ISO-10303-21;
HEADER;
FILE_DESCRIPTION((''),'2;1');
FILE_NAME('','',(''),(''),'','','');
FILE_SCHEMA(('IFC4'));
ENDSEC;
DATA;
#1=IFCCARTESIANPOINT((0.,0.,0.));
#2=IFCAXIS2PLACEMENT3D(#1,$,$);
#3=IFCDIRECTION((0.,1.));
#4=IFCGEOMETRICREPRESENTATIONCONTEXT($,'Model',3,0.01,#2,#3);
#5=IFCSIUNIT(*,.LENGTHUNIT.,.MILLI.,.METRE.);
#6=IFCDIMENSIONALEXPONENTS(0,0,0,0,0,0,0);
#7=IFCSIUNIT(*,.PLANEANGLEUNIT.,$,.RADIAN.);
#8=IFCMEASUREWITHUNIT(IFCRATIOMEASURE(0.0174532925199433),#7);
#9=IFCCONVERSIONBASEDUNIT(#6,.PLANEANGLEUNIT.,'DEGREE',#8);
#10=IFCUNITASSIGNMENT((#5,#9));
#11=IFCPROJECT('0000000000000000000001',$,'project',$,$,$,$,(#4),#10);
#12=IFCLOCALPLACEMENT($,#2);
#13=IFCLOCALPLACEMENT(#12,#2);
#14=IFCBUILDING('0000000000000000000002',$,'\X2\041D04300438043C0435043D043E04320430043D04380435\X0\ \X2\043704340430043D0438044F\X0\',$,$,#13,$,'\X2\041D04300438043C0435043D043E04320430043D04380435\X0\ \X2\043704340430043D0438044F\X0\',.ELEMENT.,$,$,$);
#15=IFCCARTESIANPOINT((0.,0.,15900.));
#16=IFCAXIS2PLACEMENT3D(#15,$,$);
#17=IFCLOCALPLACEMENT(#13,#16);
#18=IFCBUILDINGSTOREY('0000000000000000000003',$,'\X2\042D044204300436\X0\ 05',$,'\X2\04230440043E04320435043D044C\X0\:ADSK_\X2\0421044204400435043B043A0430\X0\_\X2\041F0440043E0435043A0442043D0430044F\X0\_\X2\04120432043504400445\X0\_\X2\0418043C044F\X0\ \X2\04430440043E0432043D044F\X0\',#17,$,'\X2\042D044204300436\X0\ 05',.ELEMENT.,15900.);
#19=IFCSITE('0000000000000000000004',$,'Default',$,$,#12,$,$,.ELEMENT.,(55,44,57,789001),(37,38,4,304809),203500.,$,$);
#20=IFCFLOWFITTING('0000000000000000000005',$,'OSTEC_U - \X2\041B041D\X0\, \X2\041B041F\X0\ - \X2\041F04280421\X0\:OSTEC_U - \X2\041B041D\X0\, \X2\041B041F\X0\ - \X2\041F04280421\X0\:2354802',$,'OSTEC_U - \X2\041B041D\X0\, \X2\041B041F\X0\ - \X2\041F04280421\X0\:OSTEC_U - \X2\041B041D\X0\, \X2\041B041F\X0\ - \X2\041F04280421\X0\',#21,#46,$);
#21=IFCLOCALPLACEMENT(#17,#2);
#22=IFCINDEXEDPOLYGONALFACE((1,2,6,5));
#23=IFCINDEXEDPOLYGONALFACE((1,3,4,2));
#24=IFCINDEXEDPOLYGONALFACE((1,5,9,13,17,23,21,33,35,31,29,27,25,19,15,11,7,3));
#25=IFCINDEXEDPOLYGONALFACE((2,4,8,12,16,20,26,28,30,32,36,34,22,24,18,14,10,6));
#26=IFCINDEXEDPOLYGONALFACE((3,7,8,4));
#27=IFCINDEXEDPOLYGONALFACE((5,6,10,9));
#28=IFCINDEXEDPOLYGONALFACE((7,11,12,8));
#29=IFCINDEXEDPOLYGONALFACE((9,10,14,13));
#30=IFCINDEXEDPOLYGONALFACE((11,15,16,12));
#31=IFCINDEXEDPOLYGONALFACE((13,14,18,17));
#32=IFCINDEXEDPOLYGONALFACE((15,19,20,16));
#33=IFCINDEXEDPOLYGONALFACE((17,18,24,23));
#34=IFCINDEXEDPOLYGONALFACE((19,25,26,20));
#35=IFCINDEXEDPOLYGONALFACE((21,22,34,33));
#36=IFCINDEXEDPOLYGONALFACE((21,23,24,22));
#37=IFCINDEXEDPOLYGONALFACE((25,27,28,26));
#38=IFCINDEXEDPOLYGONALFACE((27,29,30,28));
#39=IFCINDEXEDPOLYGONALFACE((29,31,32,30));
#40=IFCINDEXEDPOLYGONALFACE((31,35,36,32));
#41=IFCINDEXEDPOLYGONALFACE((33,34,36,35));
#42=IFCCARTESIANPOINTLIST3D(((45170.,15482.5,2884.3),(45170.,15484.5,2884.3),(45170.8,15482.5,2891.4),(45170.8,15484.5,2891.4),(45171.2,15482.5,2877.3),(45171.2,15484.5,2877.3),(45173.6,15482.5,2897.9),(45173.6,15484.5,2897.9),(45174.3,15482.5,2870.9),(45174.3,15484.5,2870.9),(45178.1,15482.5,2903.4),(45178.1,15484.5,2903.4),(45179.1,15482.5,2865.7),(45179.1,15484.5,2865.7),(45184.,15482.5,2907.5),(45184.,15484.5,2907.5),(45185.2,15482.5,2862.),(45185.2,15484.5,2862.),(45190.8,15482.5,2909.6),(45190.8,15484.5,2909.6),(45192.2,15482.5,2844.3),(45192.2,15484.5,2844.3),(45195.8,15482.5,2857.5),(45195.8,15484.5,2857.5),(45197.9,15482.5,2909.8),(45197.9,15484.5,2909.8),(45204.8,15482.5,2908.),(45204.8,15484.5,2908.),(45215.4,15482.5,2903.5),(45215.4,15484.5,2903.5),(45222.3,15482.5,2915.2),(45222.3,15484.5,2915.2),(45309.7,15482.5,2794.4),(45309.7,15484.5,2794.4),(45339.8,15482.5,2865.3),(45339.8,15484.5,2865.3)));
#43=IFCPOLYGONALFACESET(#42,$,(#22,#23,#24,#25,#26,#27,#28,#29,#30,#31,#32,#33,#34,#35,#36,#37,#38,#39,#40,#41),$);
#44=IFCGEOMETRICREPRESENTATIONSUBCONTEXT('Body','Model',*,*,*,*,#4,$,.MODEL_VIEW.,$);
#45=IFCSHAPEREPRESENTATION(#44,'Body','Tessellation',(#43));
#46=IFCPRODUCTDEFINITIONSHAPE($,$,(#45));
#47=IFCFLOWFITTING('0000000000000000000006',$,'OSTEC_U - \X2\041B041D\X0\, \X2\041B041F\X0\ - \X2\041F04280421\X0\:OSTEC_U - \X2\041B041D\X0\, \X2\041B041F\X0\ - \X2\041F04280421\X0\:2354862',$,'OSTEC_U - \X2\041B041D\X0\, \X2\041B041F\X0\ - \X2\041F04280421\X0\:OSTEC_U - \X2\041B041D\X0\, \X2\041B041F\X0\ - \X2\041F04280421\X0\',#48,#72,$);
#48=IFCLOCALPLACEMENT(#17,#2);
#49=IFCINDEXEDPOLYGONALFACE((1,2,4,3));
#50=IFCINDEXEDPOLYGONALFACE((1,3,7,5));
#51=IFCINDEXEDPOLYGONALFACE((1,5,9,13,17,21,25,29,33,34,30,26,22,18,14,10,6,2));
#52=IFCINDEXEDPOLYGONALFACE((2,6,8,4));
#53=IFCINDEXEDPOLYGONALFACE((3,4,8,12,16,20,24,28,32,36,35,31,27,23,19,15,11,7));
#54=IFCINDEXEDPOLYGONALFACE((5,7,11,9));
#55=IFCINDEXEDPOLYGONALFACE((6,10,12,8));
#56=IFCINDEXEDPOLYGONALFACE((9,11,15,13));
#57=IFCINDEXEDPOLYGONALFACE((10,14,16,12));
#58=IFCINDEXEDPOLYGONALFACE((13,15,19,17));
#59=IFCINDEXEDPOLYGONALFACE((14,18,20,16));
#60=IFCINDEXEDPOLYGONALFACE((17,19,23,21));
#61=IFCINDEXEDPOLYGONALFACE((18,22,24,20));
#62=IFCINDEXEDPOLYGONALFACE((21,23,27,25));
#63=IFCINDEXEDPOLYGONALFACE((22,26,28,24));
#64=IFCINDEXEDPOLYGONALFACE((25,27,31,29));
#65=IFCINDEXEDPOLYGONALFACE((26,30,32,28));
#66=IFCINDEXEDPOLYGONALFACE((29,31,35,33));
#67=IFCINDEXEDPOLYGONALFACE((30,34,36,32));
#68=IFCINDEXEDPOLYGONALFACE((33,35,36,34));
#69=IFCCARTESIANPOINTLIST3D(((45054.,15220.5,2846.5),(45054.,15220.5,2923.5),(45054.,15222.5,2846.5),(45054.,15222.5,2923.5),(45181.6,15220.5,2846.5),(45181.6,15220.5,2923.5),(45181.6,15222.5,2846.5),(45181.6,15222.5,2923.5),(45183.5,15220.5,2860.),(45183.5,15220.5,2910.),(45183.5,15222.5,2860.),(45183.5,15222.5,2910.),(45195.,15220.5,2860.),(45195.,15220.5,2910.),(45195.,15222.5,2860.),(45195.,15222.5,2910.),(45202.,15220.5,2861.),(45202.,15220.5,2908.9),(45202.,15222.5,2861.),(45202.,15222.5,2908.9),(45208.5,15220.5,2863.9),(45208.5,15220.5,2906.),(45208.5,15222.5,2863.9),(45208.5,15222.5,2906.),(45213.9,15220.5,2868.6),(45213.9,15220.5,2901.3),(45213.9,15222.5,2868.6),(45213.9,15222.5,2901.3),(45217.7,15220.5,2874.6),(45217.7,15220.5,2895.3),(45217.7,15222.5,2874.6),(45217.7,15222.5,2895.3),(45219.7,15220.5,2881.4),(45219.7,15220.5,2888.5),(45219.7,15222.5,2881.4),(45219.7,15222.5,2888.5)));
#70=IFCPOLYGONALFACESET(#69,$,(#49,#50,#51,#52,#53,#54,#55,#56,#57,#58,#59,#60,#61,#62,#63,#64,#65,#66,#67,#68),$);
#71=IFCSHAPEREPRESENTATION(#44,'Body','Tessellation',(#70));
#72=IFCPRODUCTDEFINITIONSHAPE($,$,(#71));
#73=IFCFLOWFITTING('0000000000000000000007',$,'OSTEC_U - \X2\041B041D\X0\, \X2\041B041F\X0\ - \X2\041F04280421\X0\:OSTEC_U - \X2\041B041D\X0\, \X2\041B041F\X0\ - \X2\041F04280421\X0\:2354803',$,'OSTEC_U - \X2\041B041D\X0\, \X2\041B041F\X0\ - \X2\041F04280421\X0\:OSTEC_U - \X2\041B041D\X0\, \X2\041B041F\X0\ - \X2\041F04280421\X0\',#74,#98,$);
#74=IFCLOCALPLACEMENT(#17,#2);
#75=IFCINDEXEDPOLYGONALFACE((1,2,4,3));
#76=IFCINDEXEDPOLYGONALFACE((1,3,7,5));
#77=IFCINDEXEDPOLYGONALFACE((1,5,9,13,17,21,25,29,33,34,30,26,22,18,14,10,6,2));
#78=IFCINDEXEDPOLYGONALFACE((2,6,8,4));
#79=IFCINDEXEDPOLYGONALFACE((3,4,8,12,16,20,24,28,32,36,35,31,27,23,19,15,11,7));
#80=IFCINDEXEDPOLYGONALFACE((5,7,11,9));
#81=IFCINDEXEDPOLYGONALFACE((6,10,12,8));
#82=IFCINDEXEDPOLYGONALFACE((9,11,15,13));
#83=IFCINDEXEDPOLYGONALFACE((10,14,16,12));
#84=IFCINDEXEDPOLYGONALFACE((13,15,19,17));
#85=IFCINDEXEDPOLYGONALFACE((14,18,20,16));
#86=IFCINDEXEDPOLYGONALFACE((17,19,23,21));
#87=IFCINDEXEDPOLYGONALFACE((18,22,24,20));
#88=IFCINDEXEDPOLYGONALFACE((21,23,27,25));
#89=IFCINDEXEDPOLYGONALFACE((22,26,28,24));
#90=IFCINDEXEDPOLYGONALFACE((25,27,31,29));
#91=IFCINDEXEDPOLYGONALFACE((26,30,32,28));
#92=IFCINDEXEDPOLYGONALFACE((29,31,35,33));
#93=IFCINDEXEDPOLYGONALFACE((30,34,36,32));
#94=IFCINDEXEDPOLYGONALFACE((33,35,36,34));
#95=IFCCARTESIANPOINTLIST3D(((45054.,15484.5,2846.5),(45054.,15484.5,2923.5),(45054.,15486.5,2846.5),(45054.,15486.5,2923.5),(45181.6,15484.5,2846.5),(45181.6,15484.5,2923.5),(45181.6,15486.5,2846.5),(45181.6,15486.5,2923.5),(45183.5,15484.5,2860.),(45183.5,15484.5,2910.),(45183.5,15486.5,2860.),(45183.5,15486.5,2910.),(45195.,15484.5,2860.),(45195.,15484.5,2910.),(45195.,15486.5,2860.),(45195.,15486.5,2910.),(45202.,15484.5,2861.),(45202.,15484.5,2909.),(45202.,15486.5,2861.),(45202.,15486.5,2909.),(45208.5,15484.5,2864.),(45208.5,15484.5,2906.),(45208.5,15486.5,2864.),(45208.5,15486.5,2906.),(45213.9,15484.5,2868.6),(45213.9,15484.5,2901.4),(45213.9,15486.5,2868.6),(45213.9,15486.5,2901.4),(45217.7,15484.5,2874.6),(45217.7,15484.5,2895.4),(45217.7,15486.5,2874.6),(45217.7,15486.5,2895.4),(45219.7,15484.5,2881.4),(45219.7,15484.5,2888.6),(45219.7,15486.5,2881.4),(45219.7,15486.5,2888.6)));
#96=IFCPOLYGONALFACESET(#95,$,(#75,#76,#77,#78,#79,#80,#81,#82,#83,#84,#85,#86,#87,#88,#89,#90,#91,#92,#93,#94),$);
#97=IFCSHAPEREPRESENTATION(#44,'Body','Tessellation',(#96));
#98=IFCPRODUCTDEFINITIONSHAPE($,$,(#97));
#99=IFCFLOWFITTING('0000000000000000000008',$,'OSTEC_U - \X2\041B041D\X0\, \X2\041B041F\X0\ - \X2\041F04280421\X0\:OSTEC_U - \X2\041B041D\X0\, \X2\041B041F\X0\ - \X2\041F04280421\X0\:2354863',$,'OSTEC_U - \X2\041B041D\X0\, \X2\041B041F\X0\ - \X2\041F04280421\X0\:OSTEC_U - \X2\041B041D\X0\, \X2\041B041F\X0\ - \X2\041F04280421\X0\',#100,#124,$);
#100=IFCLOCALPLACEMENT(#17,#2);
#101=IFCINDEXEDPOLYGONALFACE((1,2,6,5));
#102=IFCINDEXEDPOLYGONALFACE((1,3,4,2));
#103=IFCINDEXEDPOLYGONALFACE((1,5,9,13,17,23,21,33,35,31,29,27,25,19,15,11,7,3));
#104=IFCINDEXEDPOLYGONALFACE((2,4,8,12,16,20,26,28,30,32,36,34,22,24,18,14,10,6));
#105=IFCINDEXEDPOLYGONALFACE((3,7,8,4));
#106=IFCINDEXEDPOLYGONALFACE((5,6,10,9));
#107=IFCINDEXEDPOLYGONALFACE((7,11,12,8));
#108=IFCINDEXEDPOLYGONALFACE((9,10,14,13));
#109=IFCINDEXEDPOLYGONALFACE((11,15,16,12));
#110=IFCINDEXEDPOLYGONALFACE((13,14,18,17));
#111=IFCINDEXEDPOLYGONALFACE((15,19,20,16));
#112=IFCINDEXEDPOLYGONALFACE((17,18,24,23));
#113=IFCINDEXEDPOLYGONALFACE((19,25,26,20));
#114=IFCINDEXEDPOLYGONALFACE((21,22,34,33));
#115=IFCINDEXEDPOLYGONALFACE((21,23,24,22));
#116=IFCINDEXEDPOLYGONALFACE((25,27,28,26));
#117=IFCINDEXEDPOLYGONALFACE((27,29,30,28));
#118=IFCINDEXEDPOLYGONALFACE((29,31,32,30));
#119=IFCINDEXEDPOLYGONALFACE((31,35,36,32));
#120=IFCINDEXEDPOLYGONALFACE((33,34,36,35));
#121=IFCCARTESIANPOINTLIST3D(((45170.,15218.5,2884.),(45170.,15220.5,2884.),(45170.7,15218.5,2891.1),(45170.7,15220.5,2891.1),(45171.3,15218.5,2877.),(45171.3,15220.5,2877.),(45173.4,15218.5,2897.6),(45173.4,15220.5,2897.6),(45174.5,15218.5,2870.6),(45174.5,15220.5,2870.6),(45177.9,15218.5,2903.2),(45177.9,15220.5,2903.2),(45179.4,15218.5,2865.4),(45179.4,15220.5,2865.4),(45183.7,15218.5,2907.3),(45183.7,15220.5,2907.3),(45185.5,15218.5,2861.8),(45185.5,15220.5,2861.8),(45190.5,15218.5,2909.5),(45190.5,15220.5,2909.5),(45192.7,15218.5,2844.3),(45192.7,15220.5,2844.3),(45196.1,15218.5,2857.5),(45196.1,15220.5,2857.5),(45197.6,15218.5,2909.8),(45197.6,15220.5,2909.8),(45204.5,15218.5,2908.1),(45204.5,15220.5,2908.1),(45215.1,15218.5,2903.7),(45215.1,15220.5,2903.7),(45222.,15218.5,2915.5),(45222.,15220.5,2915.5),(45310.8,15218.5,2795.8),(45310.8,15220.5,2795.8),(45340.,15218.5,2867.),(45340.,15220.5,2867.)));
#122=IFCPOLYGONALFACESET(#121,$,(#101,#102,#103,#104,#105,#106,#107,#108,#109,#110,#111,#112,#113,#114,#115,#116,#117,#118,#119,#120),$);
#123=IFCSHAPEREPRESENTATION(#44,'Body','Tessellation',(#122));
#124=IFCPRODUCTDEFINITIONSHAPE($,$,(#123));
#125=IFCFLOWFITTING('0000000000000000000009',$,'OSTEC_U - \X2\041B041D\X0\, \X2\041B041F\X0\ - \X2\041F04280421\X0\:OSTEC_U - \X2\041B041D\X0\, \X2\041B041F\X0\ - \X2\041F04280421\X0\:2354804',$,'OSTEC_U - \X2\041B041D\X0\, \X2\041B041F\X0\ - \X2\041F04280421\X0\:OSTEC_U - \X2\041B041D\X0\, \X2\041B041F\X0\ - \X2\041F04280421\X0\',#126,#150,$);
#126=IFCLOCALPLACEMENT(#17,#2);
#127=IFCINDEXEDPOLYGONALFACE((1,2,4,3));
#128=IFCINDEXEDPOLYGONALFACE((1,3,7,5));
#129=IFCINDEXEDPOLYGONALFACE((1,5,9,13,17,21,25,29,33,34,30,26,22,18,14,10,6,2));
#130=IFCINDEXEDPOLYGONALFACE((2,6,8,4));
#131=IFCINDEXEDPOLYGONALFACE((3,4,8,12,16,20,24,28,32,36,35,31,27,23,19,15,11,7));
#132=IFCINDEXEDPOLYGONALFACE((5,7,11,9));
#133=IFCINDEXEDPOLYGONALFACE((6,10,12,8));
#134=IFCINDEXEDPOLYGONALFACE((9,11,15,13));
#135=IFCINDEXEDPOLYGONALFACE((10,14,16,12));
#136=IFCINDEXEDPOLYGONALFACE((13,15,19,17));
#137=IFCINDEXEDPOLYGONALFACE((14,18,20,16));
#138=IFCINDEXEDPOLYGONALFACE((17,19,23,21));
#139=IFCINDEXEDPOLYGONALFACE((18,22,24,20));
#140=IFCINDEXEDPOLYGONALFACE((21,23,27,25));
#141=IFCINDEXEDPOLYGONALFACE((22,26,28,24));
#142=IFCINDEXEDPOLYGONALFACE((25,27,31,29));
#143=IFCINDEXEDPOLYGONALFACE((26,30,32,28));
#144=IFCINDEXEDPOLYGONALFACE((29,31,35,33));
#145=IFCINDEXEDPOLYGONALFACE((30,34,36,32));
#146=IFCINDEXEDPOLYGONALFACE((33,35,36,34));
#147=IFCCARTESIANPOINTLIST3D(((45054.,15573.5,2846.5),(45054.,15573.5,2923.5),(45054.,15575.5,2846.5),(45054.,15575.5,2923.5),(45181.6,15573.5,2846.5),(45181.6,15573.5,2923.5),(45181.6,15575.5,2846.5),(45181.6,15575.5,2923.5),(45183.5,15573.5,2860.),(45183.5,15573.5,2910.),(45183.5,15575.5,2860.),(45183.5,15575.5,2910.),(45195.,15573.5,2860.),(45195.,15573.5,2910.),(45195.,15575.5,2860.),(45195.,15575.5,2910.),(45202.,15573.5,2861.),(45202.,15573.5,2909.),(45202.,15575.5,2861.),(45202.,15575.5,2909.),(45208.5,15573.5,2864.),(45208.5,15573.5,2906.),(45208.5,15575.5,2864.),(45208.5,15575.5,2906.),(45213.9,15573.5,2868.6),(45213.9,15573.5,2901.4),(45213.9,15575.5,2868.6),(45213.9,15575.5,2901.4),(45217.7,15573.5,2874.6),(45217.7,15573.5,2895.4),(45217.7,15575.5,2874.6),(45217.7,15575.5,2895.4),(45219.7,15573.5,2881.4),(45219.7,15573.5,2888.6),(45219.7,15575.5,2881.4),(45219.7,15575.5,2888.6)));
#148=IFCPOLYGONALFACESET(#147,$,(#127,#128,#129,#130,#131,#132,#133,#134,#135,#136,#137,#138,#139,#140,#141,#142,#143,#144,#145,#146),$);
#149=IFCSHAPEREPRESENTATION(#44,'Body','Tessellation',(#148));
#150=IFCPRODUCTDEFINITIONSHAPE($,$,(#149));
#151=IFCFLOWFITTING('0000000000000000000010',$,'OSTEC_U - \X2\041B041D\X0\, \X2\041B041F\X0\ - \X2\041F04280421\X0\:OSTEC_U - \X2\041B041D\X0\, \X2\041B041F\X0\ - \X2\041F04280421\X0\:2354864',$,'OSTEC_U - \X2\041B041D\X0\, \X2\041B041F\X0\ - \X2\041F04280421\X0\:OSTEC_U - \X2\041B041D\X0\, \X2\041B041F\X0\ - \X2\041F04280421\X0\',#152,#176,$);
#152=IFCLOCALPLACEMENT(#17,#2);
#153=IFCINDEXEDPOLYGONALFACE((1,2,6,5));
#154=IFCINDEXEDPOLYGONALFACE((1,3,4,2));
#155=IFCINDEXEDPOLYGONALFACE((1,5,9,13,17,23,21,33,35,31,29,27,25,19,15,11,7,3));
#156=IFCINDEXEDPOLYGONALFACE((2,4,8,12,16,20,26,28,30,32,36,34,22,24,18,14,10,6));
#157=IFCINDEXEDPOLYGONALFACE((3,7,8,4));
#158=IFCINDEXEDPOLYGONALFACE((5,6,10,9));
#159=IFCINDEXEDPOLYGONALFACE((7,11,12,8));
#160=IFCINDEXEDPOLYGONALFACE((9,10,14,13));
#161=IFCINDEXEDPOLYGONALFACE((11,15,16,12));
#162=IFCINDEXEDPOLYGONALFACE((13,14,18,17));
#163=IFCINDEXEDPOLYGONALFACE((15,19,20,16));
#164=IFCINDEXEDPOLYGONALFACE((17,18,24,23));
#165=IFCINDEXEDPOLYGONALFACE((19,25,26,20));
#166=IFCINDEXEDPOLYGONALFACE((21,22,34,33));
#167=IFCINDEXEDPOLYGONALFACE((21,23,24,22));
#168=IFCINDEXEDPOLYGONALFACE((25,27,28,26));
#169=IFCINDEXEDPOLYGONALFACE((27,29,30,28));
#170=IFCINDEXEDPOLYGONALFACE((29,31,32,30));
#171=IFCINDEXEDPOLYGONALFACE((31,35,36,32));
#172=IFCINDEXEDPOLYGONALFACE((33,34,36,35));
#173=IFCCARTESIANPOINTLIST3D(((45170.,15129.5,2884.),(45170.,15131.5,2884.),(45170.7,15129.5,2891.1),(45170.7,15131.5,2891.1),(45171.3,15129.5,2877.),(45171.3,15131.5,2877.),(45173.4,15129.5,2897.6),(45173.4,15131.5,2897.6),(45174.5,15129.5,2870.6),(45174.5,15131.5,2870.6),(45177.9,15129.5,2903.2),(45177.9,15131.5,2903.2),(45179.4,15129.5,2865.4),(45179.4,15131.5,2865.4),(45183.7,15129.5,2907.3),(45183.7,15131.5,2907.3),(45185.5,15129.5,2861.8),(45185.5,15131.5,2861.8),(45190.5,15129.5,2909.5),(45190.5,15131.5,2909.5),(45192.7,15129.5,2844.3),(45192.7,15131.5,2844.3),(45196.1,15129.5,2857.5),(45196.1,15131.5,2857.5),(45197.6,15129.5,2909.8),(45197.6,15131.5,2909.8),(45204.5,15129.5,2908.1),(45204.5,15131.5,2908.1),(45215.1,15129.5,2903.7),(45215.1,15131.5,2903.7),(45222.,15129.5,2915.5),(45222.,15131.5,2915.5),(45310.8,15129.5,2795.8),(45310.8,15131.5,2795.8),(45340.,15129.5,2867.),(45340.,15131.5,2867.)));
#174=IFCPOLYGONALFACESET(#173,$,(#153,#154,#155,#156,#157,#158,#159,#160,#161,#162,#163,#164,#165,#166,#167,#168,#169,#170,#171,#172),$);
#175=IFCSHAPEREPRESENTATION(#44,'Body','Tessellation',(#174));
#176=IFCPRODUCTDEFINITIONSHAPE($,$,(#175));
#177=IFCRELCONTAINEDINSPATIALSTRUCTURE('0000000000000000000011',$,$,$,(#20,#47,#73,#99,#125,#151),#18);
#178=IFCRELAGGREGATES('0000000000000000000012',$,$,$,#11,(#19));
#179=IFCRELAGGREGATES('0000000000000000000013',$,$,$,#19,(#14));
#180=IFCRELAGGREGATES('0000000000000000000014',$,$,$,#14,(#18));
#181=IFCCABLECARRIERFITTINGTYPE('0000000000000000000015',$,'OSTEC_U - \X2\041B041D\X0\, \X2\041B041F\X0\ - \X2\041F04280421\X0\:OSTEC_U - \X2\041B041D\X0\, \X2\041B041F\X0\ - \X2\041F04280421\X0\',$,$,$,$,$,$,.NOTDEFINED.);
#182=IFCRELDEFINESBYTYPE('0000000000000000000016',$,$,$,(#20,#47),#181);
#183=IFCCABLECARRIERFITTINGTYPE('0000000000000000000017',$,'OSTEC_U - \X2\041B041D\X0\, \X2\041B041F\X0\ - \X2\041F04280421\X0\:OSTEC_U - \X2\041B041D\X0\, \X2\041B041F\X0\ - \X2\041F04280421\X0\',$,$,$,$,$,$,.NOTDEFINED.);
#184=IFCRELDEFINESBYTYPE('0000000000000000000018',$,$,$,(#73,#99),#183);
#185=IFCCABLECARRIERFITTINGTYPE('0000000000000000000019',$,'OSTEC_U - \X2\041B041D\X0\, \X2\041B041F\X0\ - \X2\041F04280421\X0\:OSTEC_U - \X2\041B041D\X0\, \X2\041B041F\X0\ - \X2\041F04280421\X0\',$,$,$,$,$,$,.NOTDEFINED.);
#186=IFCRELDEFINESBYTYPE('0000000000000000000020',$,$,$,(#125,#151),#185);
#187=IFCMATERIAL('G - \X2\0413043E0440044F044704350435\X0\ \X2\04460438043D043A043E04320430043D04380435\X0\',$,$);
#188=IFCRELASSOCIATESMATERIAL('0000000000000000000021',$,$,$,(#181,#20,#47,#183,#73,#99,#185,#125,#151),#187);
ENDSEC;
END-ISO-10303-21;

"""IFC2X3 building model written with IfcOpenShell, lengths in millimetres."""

from ifc_helpers import new_model, entity, si_unit, converted_unit, direction, frame, frame_2d, origin, place, context, subcontext, project, spatial, polyline, circle_curve, parameter, trimmed, segment, composite_curve, outline, extrude, source, transform, mapped, material, type_object, type_shapes, element, save


model = new_model("IFC2X3")

# Units and contexts
model_context = context("Model", 3, precision=0.01, world=origin(), true_north=direction((0.0, 1.0)))
body_context = subcontext(model_context, "Body", "Model", "MODEL_VIEW")
ifc_project = project(units=[si_unit("LENGTHUNIT", "METRE", prefix="MILLI"), converted_unit("PLANEANGLEUNIT", "DEGREE", entity("IfcRatioMeasure", 0.0174532925199433), si_unit("PLANEANGLEUNIT", "RADIAN"), dimensions=[0, 0, 0, 0, 0, 0, 0])], contexts=[model_context])

# Site, building, storey
site_placement = place(None, frame((0.0, 0.0, 0.0)))
site = spatial("IfcSite", under=ifc_project, at=site_placement, Name="Default", CompositionType="ELEMENT", RefLatitude=(55, 44, 57, 789001), RefLongitude=(37, 38, 4, 304809), RefElevation=203500.0)
building_placement = place(site_placement, origin())
building = spatial("IfcBuilding", under=site, at=building_placement, Name="Наименование здания", LongName="Наименование здания", CompositionType="ELEMENT")
storey_placement = place(building_placement, frame((0.0, 0.0, 15900.0)))
storey = spatial("IfcBuildingStorey", under=building, at=storey_placement, Name="Этаж 05", ObjectType="Уровень:ADSK_Стрелка_Проектная_Вверх_Имя уровня", LongName="Этаж 05", CompositionType="ELEMENT", Elevation=15900.0)

# Flow fittings
ifc_material_1 = material(Name="G - Горячее цинкование")
cable_carrier_fitting_type_1 = type_object("IfcCableCarrierFittingType", Name="OSTEC_U - ЛН, ЛП - ПШС:OSTEC_U - ЛН, ЛП - ПШС", PredefinedType="NOTDEFINED", material=ifc_material_1)
shared_shape_1 = source(origin(), body_context, "Body", "SweptSolid", [
    extrude(outline(composite_curve([segment(trimmed(circle_curve(frame_2d((-41.5, 0.0), x_axis=(1.0, 0.0)), 25.0), [parameter(90.0)], [parameter(270.0)], True, "PARAMETER"), True, "CONTINUOUS"), segment(polyline([(-41.5, -25.0), (-30.0, -25.0)]), True, "CONTINUOUS"), segment(polyline([(-30.0, -25.0), (-28.1, -38.5)]), True, "CONTINUOUS"), segment(polyline([(-28.1, -38.5), (99.5, -38.5)]), True, "CONTINUOUS"), segment(polyline([(99.5, -38.5), (99.5, 38.5)]), True, "CONTINUOUS"), segment(polyline([(99.5, 38.5), (-28.1, 38.5)]), True, "CONTINUOUS"), segment(polyline([(-28.1, 38.5), (-30.0, 25.0)]), True, "CONTINUOUS"), segment(polyline([(-30.0, 25.0), (-41.5, 25.0)]), True, "CONTINUOUS")], self_intersect=False)), frame((41.5, 0.0, 0.0)), (0.0, 0.0, 1.0), 2.0),
])
type_shapes(cable_carrier_fitting_type_1, [shared_shape_1])
for number, where, z_axis, x_axis, name in (
    (1, (45195.0, 15484.5, 2885.0), (0.0, -1.0, 0.0), (0.920411, 0.0, -0.390951), "OSTEC_U - ЛН, ЛП - ПШС:OSTEC_U - ЛН, ЛП - ПШС:2354802"),
    (2, (45195.0, 15220.5, 2885.0), (0.0, 1.0, 0.0), (-1.0, 0.0, 0.0), "OSTEC_U - ЛН, ЛП - ПШС:OSTEC_U - ЛН, ЛП - ПШС:2354862"),
):
    element("IfcFlowFitting", number, at=place(storey_placement, frame(where, z_axis=z_axis, x_axis=x_axis)), inside=storey, type_object=cable_carrier_fitting_type_1, material=ifc_material_1, Name=name, ObjectType="OSTEC_U - ЛН, ЛП - ПШС:OSTEC_U - ЛН, ЛП - ПШС", context=body_context, shape_type="MappedRepresentation", body=[
        mapped(shared_shape_1, transform((0.0, 0.0, 0.0), scale=1.0)),
    ])
cable_carrier_fitting_type_2 = type_object("IfcCableCarrierFittingType", Name="OSTEC_U - ЛН, ЛП - ПШС:OSTEC_U - ЛН, ЛП - ПШС", PredefinedType="NOTDEFINED", material=ifc_material_1)
shared_shape_2 = source(origin(), body_context, "Body", "SweptSolid", [
    extrude(outline(composite_curve([segment(trimmed(circle_curve(frame_2d((-41.5, 0.0), x_axis=(1.0, 0.0)), 25.0), [parameter(90.0)], [parameter(270.0)], True, "PARAMETER"), True, "CONTINUOUS"), segment(polyline([(-41.5, -25.0), (-30.0, -25.0)]), True, "CONTINUOUS"), segment(polyline([(-30.0, -25.0), (-28.1, -38.5)]), True, "CONTINUOUS"), segment(polyline([(-28.1, -38.5), (99.5, -38.5)]), True, "CONTINUOUS"), segment(polyline([(99.5, -38.5), (99.5, 38.5)]), True, "CONTINUOUS"), segment(polyline([(99.5, 38.5), (-28.1, 38.5)]), True, "CONTINUOUS"), segment(polyline([(-28.1, 38.5), (-30.0, 25.0)]), True, "CONTINUOUS"), segment(polyline([(-30.0, 25.0), (-41.5, 25.0)]), True, "CONTINUOUS")], self_intersect=False)), frame((41.5, 0.0, 0.0), z_axis=(0.0, 0.0, -1.0), x_axis=(1.0, 0.0, 0.0)), (0.0, 0.0, -1.0), 2.0),
])
type_shapes(cable_carrier_fitting_type_2, [shared_shape_2])
for number, where, z_axis, x_axis, name in (
    (3, (45195.0, 15486.5, 2885.0), (0.0, -1.0, 0.0), (-1.0, 0.0, 0.0), "OSTEC_U - ЛН, ЛП - ПШС:OSTEC_U - ЛН, ЛП - ПШС:2354803"),
    (4, (45195.0, 15218.5, 2885.0), (0.0, 1.0, 0.0), (0.925113, 0.0, -0.379692), "OSTEC_U - ЛН, ЛП - ПШС:OSTEC_U - ЛН, ЛП - ПШС:2354863"),
):
    element("IfcFlowFitting", number, at=place(storey_placement, frame(where, z_axis=z_axis, x_axis=x_axis)), inside=storey, type_object=cable_carrier_fitting_type_2, material=ifc_material_1, Name=name, ObjectType="OSTEC_U - ЛН, ЛП - ПШС:OSTEC_U - ЛН, ЛП - ПШС", context=body_context, shape_type="MappedRepresentation", body=[
        mapped(shared_shape_2, transform((0.0, 0.0, 0.0), scale=1.0)),
    ])
cable_carrier_fitting_type_3 = type_object("IfcCableCarrierFittingType", Name="OSTEC_U - ЛН, ЛП - ПШС:OSTEC_U - ЛН, ЛП - ПШС", PredefinedType="NOTDEFINED", material=ifc_material_1)
shared_shape_3 = source(origin(), body_context, "Body", "SweptSolid", [
    extrude(outline(composite_curve([segment(trimmed(circle_curve(frame_2d((-41.5, 0.0), x_axis=(1.0, 0.0)), 25.0), [parameter(90.0)], [parameter(270.0)], True, "PARAMETER"), True, "CONTINUOUS"), segment(polyline([(-41.5, -25.0), (-30.0, -25.0)]), True, "CONTINUOUS"), segment(polyline([(-30.0, -25.0), (-28.1, -38.5)]), True, "CONTINUOUS"), segment(polyline([(-28.1, -38.5), (99.5, -38.5)]), True, "CONTINUOUS"), segment(polyline([(99.5, -38.5), (99.5, 38.5)]), True, "CONTINUOUS"), segment(polyline([(99.5, 38.5), (-28.1, 38.5)]), True, "CONTINUOUS"), segment(polyline([(-28.1, 38.5), (-30.0, 25.0)]), True, "CONTINUOUS"), segment(polyline([(-30.0, 25.0), (-41.5, 25.0)]), True, "CONTINUOUS")], self_intersect=False)), frame((41.5, 0.0, 0.0)), (0.0, 0.0, 1.0), 2.0),
])
type_shapes(cable_carrier_fitting_type_3, [shared_shape_3])
for number, where, z_axis, x_axis, name in (
    (5, (45195.0, 15573.5, 2885.0), (0.0, 1.0, 0.0), (-1.0, 0.0, 0.0), "OSTEC_U - ЛН, ЛП - ПШС:OSTEC_U - ЛН, ЛП - ПШС:2354804"),
    (6, (45195.0, 15131.5, 2885.0), (0.0, -1.0, 0.0), (0.925113, 0.0, -0.379692), "OSTEC_U - ЛН, ЛП - ПШС:OSTEC_U - ЛН, ЛП - ПШС:2354864"),
):
    element("IfcFlowFitting", number, at=place(storey_placement, frame(where, z_axis=z_axis, x_axis=x_axis)), inside=storey, type_object=cable_carrier_fitting_type_3, material=ifc_material_1, Name=name, ObjectType="OSTEC_U - ЛН, ЛП - ПШС:OSTEC_U - ЛН, ЛП - ПШС", context=body_context, shape_type="MappedRepresentation", body=[
        mapped(shared_shape_3, transform((0.0, 0.0, 0.0), scale=1.0)),
    ])

save(model, "model.ifc")
